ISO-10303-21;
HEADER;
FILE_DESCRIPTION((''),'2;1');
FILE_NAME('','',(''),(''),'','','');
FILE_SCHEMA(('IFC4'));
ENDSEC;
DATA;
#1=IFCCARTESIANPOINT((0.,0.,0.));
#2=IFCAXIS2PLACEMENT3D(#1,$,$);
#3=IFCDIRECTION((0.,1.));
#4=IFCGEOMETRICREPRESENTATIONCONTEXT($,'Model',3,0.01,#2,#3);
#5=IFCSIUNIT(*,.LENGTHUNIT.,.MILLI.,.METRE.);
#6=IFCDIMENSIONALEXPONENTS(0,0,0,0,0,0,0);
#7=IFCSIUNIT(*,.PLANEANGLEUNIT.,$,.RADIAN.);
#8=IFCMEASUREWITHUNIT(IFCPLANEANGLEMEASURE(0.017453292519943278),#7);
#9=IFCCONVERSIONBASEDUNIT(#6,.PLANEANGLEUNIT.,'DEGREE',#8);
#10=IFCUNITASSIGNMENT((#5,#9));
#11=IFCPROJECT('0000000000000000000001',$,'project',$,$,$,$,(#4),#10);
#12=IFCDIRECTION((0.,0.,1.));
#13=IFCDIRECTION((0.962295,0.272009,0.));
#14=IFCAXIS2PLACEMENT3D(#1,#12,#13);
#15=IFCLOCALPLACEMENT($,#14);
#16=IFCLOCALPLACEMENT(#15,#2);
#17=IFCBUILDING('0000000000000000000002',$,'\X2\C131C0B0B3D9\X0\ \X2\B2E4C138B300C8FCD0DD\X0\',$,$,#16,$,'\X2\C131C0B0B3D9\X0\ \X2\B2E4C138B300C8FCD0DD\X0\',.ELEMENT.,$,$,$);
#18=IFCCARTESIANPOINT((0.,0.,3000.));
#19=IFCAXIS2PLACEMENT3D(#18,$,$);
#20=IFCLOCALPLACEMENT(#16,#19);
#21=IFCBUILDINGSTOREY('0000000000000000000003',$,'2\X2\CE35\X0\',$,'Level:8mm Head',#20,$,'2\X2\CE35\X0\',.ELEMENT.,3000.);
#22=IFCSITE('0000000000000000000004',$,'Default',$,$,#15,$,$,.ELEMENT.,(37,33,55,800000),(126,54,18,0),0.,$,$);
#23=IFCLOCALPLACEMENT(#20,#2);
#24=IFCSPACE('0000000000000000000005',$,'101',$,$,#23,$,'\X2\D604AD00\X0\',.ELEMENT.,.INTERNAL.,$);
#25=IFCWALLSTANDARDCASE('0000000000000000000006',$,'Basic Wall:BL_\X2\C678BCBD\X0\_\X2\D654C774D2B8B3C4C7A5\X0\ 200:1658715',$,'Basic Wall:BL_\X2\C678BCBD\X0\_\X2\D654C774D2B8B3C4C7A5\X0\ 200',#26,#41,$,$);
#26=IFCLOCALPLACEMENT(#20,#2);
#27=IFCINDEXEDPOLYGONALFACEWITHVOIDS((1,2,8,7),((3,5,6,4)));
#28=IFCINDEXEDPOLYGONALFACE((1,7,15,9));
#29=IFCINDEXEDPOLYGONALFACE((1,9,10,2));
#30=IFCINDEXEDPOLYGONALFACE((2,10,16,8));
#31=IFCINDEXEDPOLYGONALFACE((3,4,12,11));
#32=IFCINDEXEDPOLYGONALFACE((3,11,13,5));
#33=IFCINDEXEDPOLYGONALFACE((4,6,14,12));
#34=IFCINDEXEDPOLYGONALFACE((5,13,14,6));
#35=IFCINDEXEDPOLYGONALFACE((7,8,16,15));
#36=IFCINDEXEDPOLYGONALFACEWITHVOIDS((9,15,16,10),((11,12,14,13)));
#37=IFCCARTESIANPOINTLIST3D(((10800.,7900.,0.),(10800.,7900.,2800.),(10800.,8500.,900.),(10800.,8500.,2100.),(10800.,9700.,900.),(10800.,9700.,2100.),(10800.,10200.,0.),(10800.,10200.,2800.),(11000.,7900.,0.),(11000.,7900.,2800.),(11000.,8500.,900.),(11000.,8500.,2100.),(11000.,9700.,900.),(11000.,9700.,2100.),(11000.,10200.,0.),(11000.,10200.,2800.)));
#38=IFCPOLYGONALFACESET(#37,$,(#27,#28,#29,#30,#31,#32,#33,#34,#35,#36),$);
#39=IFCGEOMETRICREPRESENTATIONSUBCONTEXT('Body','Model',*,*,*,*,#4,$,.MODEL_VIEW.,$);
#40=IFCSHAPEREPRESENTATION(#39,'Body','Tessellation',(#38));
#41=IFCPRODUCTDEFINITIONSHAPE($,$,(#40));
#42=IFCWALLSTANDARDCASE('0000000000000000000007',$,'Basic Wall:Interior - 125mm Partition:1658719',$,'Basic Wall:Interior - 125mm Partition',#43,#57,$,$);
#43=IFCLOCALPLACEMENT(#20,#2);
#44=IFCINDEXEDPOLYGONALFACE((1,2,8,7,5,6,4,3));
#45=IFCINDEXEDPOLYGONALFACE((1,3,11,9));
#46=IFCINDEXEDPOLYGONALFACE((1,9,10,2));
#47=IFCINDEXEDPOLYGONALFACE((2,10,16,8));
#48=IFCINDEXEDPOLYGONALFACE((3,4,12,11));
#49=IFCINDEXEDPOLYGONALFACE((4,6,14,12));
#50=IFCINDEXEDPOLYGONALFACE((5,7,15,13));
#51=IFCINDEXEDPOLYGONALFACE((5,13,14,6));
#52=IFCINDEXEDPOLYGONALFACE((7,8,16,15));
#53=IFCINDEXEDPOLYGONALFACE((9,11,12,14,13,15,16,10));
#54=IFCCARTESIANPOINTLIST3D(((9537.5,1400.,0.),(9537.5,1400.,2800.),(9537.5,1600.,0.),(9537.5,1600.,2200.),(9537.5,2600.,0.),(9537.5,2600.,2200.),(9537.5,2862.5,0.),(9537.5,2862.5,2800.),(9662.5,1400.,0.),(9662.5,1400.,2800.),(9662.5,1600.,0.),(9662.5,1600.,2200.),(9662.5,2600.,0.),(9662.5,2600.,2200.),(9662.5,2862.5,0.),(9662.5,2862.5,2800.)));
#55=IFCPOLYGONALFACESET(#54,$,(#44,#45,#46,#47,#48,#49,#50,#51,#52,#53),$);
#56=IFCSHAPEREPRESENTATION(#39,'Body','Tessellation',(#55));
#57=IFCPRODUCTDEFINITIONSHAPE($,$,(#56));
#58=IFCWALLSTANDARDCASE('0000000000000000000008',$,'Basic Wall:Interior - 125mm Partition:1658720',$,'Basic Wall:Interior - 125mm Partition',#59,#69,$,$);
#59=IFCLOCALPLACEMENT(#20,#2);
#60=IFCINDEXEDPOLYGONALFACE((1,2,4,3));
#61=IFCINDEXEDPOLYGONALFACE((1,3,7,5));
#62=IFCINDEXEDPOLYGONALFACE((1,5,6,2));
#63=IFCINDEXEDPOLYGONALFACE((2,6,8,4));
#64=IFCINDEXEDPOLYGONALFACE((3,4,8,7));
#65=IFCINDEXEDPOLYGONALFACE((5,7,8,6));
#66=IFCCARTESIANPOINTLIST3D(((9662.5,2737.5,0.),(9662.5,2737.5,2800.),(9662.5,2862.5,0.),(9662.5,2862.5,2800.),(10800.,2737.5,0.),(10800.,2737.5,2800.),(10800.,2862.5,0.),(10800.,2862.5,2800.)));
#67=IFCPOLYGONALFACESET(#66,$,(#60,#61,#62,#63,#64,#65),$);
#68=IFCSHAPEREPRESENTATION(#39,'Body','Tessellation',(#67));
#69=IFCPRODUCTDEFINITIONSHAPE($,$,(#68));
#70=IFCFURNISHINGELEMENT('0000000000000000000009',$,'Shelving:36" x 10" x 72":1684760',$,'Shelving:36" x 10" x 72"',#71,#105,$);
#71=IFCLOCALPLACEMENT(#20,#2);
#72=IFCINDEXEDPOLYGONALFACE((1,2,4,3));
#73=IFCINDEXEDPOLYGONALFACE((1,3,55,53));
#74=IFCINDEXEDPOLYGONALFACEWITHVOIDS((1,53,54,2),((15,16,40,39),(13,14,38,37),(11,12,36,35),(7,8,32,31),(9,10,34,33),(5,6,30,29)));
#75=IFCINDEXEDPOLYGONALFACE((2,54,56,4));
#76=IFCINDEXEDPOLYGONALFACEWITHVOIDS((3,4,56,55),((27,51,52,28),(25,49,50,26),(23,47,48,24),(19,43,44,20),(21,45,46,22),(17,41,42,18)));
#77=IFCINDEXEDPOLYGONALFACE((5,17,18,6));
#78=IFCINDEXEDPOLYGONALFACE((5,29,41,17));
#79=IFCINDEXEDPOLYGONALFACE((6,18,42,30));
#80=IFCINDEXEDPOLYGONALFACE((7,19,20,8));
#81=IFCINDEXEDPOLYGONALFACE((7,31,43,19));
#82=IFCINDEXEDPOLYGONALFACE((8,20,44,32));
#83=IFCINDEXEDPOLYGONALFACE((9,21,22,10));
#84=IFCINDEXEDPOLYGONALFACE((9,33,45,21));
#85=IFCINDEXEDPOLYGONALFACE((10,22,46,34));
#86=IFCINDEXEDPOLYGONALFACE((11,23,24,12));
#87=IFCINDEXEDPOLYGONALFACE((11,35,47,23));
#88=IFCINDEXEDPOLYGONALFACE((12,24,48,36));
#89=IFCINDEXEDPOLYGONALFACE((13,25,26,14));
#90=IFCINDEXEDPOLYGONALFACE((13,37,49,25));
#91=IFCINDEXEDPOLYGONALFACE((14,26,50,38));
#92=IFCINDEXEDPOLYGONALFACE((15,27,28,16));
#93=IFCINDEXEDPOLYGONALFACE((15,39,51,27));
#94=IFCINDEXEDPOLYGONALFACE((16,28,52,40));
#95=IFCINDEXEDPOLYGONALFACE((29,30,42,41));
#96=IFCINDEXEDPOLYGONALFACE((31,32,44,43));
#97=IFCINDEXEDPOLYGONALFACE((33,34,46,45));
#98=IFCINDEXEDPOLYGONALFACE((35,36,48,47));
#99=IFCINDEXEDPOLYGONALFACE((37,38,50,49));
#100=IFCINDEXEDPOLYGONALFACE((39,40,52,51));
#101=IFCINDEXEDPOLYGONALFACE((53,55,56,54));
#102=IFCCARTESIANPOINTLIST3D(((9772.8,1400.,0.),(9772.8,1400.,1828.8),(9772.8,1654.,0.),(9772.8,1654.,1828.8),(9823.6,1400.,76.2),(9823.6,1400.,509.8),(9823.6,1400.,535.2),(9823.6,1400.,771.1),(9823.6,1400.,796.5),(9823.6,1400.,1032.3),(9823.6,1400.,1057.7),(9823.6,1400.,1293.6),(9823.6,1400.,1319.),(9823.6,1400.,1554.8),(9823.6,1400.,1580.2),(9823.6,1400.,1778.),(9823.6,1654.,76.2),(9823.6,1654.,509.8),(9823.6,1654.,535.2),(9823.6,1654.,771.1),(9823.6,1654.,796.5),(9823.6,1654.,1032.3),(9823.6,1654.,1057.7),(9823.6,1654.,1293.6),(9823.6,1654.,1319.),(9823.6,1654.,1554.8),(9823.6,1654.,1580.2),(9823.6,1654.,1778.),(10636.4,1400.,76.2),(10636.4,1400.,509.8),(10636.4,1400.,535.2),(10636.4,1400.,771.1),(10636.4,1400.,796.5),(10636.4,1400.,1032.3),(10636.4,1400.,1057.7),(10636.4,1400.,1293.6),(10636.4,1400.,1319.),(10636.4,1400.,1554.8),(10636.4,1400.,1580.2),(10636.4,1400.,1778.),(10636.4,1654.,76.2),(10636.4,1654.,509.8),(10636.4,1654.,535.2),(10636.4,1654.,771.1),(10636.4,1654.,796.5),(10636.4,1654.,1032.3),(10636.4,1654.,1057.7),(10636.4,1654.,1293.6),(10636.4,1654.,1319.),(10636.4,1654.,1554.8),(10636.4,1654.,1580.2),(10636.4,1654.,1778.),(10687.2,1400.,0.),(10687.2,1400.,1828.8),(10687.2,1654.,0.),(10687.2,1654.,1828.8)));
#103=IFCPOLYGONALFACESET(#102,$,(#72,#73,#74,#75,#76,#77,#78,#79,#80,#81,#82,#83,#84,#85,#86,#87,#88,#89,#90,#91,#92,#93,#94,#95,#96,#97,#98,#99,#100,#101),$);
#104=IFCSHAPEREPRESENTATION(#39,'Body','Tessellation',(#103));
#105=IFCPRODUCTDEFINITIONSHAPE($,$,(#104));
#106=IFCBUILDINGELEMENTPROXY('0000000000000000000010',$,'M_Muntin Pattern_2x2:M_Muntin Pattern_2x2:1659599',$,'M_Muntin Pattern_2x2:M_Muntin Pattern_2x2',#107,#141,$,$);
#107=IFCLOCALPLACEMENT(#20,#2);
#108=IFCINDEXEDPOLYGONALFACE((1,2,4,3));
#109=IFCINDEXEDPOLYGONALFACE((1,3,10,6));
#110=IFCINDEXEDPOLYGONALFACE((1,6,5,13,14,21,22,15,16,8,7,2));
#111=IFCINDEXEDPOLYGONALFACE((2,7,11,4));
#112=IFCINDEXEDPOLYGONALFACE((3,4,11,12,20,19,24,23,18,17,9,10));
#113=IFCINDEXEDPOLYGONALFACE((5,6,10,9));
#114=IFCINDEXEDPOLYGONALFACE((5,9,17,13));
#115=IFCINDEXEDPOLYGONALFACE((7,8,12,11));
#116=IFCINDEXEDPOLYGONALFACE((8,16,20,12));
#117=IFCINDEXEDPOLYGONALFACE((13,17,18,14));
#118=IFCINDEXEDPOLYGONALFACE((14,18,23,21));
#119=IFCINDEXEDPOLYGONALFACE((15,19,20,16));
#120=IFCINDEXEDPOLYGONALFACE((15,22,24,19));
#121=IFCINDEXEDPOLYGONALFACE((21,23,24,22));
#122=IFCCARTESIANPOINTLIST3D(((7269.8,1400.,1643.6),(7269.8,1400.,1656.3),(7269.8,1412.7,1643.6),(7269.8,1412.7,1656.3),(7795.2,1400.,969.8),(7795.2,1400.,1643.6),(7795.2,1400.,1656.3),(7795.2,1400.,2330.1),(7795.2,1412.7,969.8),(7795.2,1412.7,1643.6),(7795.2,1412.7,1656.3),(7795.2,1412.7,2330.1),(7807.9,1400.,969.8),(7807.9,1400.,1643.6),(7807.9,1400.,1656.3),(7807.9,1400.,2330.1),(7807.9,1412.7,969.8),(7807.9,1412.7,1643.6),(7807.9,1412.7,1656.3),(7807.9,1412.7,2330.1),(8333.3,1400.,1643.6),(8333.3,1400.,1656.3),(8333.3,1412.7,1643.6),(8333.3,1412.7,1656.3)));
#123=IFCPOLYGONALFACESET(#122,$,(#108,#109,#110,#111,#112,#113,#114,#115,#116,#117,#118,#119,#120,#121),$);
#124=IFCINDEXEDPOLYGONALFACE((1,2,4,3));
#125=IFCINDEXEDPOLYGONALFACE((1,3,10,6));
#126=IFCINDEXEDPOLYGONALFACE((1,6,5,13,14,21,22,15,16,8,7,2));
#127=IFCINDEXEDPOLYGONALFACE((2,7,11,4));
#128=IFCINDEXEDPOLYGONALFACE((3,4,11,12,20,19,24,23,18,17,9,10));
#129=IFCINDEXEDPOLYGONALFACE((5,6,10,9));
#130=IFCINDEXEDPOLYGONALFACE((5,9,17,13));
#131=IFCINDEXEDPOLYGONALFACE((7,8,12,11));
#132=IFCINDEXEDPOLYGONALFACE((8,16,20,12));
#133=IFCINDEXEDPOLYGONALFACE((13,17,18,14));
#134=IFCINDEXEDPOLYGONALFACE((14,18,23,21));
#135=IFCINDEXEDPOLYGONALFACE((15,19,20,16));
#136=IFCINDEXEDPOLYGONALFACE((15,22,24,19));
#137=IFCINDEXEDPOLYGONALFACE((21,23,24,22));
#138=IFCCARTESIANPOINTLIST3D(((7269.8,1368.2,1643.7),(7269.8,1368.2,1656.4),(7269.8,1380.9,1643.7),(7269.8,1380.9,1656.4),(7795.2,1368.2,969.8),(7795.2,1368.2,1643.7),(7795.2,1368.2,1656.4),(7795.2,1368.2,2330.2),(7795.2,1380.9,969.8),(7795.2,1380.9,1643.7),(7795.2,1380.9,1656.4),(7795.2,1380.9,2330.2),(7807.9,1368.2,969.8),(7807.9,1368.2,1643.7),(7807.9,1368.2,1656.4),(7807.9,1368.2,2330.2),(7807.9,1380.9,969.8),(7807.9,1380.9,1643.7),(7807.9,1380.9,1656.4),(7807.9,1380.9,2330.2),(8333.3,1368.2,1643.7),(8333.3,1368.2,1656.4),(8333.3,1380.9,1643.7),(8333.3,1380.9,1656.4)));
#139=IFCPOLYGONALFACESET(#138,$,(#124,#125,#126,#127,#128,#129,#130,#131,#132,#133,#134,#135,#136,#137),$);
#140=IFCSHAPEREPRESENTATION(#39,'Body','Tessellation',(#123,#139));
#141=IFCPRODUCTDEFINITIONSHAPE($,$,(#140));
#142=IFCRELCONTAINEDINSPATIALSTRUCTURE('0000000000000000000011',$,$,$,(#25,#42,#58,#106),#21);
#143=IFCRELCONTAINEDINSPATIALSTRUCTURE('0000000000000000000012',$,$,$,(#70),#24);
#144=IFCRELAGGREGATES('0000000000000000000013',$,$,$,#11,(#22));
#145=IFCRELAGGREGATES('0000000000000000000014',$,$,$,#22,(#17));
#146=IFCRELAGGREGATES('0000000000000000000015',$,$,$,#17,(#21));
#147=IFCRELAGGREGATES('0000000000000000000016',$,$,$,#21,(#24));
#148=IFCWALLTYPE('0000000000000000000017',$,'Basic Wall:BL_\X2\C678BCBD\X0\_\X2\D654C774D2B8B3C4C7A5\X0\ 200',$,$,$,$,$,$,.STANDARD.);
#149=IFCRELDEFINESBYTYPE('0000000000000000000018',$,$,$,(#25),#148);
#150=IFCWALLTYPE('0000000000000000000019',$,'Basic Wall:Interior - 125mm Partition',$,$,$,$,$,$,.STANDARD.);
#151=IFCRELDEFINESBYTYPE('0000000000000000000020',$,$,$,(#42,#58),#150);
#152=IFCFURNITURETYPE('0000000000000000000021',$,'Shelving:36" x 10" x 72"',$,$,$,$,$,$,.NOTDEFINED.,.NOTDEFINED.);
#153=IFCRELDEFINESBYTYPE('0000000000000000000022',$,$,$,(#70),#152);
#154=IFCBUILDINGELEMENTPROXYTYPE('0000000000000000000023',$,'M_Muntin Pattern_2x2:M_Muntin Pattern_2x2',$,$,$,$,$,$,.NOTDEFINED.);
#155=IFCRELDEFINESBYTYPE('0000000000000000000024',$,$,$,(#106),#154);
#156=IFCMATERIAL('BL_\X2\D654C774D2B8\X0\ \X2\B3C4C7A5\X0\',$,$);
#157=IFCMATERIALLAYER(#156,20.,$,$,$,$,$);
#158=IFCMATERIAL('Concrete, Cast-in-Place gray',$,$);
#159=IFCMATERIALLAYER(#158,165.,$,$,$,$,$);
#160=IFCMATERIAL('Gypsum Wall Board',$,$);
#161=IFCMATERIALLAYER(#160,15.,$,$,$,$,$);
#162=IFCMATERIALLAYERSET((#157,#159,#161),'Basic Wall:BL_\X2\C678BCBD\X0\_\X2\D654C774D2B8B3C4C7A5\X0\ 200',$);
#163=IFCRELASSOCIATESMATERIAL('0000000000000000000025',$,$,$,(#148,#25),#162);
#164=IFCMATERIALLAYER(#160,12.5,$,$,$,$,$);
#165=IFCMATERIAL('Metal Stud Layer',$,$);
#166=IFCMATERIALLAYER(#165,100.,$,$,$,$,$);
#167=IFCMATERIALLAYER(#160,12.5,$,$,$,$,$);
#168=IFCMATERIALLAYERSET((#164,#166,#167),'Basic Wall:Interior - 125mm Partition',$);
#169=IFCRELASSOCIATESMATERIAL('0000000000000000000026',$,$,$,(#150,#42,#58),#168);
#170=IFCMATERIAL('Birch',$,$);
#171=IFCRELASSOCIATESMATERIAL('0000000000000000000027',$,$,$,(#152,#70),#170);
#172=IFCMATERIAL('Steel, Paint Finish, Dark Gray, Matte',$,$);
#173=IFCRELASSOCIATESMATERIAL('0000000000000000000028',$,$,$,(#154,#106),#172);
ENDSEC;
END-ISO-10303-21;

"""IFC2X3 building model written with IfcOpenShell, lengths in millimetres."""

from ifc_helpers import new_model, entity, si_unit, converted_unit, direction, frame, frame_2d, origin, place, context, subcontext, project, spatial, polyline, rectangle, outline, extrude, source, transform, mapped, material, layer, layer_set, layer_usage, type_object, type_shapes, element, save


model = new_model("IFC2X3")

# Units and contexts
model_context = context("Model", 3, precision=0.01, world=origin(), true_north=direction((0.0, 1.0)))
body_context = subcontext(model_context, "Body", "Model", "MODEL_VIEW")
ifc_project = project(units=[si_unit("LENGTHUNIT", "METRE", prefix="MILLI"), converted_unit("PLANEANGLEUNIT", "DEGREE", entity("IfcPlaneAngleMeasure", 0.017453292519943278), si_unit("PLANEANGLEUNIT", "RADIAN"), dimensions=[0, 0, 0, 0, 0, 0, 0])], contexts=[model_context])

# Site, building, storey
site_placement = place(None, frame((0.0, 0.0, 0.0), z_axis=(0.0, 0.0, 1.0), x_axis=(0.962295, 0.272009, 0.0)))
site = spatial("IfcSite", under=ifc_project, at=site_placement, Name="Default", CompositionType="ELEMENT", RefLatitude=(37, 33, 55, 800000), RefLongitude=(126, 54, 18, 0), RefElevation=0.0)
building_placement = place(site_placement, origin())
building = spatial("IfcBuilding", under=site, at=building_placement, Name="성산동 다세대주택", LongName="성산동 다세대주택", CompositionType="ELEMENT")
storey_placement = place(building_placement, frame((0.0, 0.0, 3000.0)))
storey = spatial("IfcBuildingStorey", under=building, at=storey_placement, Name="2층", ObjectType="Level:8mm Head", LongName="2층", CompositionType="ELEMENT", Elevation=3000.0)

# Shared definitions
ifc_material_1 = material(Name="Steel, Paint Finish, Dark Gray, Matte")
ifc_material_2 = material(Name="Concrete, Cast-in-Place gray")
ifc_material_3 = material(Name="Gypsum Wall Board")

# Walls, openings
ifc_material_4 = material(Name="BL_화이트 도장")
ifc_layer_1 = layer(ifc_material_4, 20.0)
ifc_layer_2 = layer(ifc_material_2, 165.0)
ifc_layer_3 = layer(ifc_material_3, 15.0)
ifc_layer_set_1 = layer_set([ifc_layer_1, ifc_layer_2, ifc_layer_3], Name="Basic Wall:BL_외벽_화이트도장 200")
ifc_layer_usage_1 = layer_usage(ifc_layer_set_1, "AXIS2", "NEGATIVE", 100.0)
wall_type_1 = type_object("IfcWallType", Name="Basic Wall:BL_외벽_화이트도장 200", PredefinedType="STANDARD", material=ifc_layer_set_1)
wall_1_placement = place(storey_placement, frame((10900.0, 10200.0, 0.0), z_axis=(0.0, 0.0, 1.0), x_axis=(0.0, -1.0, 0.0)))
wall_1 = element("IfcWallStandardCase", 1, at=wall_1_placement, inside=storey, type_object=wall_type_1, material=ifc_layer_usage_1, Name="Basic Wall:BL_외벽_화이트도장 200:1658715", ObjectType="Basic Wall:BL_외벽_화이트도장 200", context=body_context, shape_type="SweptSolid", body=[
    extrude(rectangle(XDim=2300.0, YDim=200.0, at=frame_2d((1150.0, 0.0), x_axis=(-1.0, 0.0))), origin(), (0.0, 0.0, 1.0), 2800.0),
])
opening_1_placement = place(wall_1_placement, frame((500.0, -100.0, 900.0)))
element("IfcOpeningElement", 2, at=opening_1_placement, cuts=wall_1, ObjectType="Opening", context=body_context, shape_type="SweptSolid", body=[
    extrude(rectangle(XDim=1200.0, YDim=1200.0, at=frame_2d((600.0, 600.0), x_axis=(-1.0, 0.0))), frame((0.0, 0.0, 0.0), z_axis=(0.0, 1.0, 0.0), x_axis=(0.0, 0.0, 1.0)), (0.0, 0.0, 1.0), 200.0),
])
ifc_layer_4 = layer(ifc_material_3, 12.5)
ifc_material_5 = material(Name="Metal Stud Layer")
ifc_layer_5 = layer(ifc_material_5, 100.0)
ifc_layer_6 = layer(ifc_material_3, 12.5)
ifc_layer_set_2 = layer_set([ifc_layer_4, ifc_layer_5, ifc_layer_6], Name="Basic Wall:Interior - 125mm Partition")
ifc_layer_usage_2 = layer_usage(ifc_layer_set_2, "AXIS2", "NEGATIVE", 62.5)
wall_type_2 = type_object("IfcWallType", Name="Basic Wall:Interior - 125mm Partition", PredefinedType="STANDARD", material=ifc_layer_set_2)
wall_2_placement = place(storey_placement, frame((9600.0, 1400.0, 0.0), z_axis=(0.0, 0.0, 1.0), x_axis=(0.0, 1.0, 0.0)))
wall_2 = element("IfcWallStandardCase", 3, at=wall_2_placement, inside=storey, type_object=wall_type_2, material=ifc_layer_usage_2, Name="Basic Wall:Interior - 125mm Partition:1658719", ObjectType="Basic Wall:Interior - 125mm Partition", context=body_context, shape_type="SweptSolid", body=[
    extrude(rectangle(XDim=1462.5, YDim=125.0, at=frame_2d((731.2, 0.0), x_axis=(-1.0, 0.0))), origin(), (0.0, 0.0, 1.0), 2800.0),
])
opening_2_placement = place(wall_2_placement, frame((200.0, -62.5, 0.0)))
element("IfcOpeningElement", 4, at=opening_2_placement, cuts=wall_2, ObjectType="Opening", context=body_context, shape_type="SweptSolid", body=[
    extrude(rectangle(XDim=2200.0, YDim=1000.0, at=frame_2d((1100.0, 500.0), x_axis=(1.0, 0.0))), frame((0.0, 0.0, 0.0), z_axis=(0.0, 1.0, 0.0), x_axis=(0.0, 0.0, 1.0)), (0.0, 0.0, 1.0), 125.0),
])

# Wall
ifc_layer_usage_3 = layer_usage(ifc_layer_set_2, "AXIS2", "NEGATIVE", 62.5)
wall_3_placement = place(storey_placement, frame((9662.5, 2800.0, 0.0)))
element("IfcWallStandardCase", 5, at=wall_3_placement, inside=storey, type_object=wall_type_2, material=ifc_layer_usage_3, Name="Basic Wall:Interior - 125mm Partition:1658720", ObjectType="Basic Wall:Interior - 125mm Partition", context=body_context, shape_type="SweptSolid", body=[
    extrude(rectangle(XDim=1137.5, YDim=125.0, at=frame_2d((568.7, 0.0), x_axis=(-1.0, 0.0))), origin(), (0.0, 0.0, 1.0), 2800.0),
])

# Shared definitions
space_1_placement = place(storey_placement, origin())
space_1 = spatial("IfcSpace", under=storey, at=space_1_placement, Name="101", LongName="현관", CompositionType="ELEMENT", InteriorOrExteriorSpace="INTERNAL")

# Furnishing element
ifc_material_6 = material(Name="Birch")
furniture_type_1 = type_object("IfcFurnitureType", Name="Shelving:36\" x 10\" x 72\"", AssemblyPlace="NOTDEFINED", material=ifc_material_6)
shared_shape_1 = source(origin(), body_context, "Body", "SweptSolid", [
    extrude(outline(polyline([(-457.2, -914.4), (457.2, -914.4), (457.2, 914.4), (-457.2, 914.4), (-457.2, -914.4)]), holes=[polyline([(-406.4, 863.6), (406.4, 863.6), (406.4, 665.8), (-406.4, 665.8), (-406.4, 863.6)]), polyline([(-406.4, -838.2), (-406.4, -404.6), (406.4, -404.6), (406.4, -838.2), (-406.4, -838.2)]), polyline([(406.4, 143.3), (-406.4, 143.3), (-406.4, 379.2), (406.4, 379.2), (406.4, 143.3)]), polyline([(-406.4, 640.4), (406.4, 640.4), (406.4, 404.6), (-406.4, 404.6), (-406.4, 640.4)]), polyline([(-406.4, 117.9), (406.4, 117.9), (406.4, -117.9), (-406.4, -117.9), (-406.4, 117.9)]), polyline([(-406.4, -143.3), (406.4, -143.3), (406.4, -379.2), (-406.4, -379.2), (-406.4, -143.3)])]), frame((0.0, -431.8, 914.4), z_axis=(0.0, 1.0, 0.0), x_axis=(-1.0, 0.0, 0.0)), (0.0, 0.0, 1.0), 254.0),
])
type_shapes(furniture_type_1, [shared_shape_1])
furnishing_1_placement = place(space_1_placement, frame((10230.0, 1222.2, 0.0), z_axis=(0.0, 0.0, 1.0), x_axis=(-1.0, 0.0, 0.0)))
element("IfcFurnishingElement", 6, at=furnishing_1_placement, inside=space_1, type_object=furniture_type_1, material=ifc_material_6, Name="Shelving:36\" x 10\" x 72\":1684760", ObjectType="Shelving:36\" x 10\" x 72\"", context=body_context, shape_type="MappedRepresentation", body=[
    mapped(shared_shape_1, transform((0.0, 0.0, 0.0), scale=1.0)),
])

# Building element proxy
building_element_proxy_type_1 = type_object("IfcBuildingElementProxyType", Name="M_Muntin Pattern_2x2:M_Muntin Pattern_2x2", PredefinedType="NOTDEFINED", material=ifc_material_1)
shared_shape_2 = source(origin(), body_context, "Body", "SweptSolid", [
    extrude(outline(polyline([(6.4, -6.4), (680.1, -6.4), (680.1, 6.3), (6.4, 6.3), (6.4, 531.7), (-6.3, 531.7), (-6.3, 6.3), (-680.2, 6.3), (-680.2, -6.4), (-6.3, -6.4), (-6.3, -531.7), (6.4, -531.7), (6.4, -6.4)])), frame((0.0, 9.5, 680.1), z_axis=(0.0, 1.0, 0.0), x_axis=(0.0, 0.0, 1.0)), (0.0, 0.0, 1.0), 12.7),
    extrude(outline(polyline([(6.4, -6.4), (680.2, -6.4), (680.2, 6.3), (6.4, 6.3), (6.4, 531.7), (-6.3, 531.7), (-6.3, 6.3), (-680.2, 6.3), (-680.2, -6.4), (-6.3, -6.4), (-6.3, -531.7), (6.4, -531.7), (6.4, -6.4)])), frame((0.0, -22.2, 680.2), z_axis=(0.0, 1.0, 0.0), x_axis=(0.0, 0.0, 1.0)), (0.0, 0.0, 1.0), 12.7),
])
type_shapes(building_element_proxy_type_1, [shared_shape_2])
proxy_1_placement = place(storey_placement, frame((7801.6, 1390.5, 969.8)))
element("IfcBuildingElementProxy", 7, at=proxy_1_placement, inside=storey, type_object=building_element_proxy_type_1, material=ifc_material_1, Name="M_Muntin Pattern_2x2:M_Muntin Pattern_2x2:1659599", ObjectType="M_Muntin Pattern_2x2:M_Muntin Pattern_2x2", context=body_context, shape_type="MappedRepresentation", body=[
    mapped(shared_shape_2, transform((0.0, 0.0, 0.0), scale=1.0)),
])

save(model, "model.ifc")
